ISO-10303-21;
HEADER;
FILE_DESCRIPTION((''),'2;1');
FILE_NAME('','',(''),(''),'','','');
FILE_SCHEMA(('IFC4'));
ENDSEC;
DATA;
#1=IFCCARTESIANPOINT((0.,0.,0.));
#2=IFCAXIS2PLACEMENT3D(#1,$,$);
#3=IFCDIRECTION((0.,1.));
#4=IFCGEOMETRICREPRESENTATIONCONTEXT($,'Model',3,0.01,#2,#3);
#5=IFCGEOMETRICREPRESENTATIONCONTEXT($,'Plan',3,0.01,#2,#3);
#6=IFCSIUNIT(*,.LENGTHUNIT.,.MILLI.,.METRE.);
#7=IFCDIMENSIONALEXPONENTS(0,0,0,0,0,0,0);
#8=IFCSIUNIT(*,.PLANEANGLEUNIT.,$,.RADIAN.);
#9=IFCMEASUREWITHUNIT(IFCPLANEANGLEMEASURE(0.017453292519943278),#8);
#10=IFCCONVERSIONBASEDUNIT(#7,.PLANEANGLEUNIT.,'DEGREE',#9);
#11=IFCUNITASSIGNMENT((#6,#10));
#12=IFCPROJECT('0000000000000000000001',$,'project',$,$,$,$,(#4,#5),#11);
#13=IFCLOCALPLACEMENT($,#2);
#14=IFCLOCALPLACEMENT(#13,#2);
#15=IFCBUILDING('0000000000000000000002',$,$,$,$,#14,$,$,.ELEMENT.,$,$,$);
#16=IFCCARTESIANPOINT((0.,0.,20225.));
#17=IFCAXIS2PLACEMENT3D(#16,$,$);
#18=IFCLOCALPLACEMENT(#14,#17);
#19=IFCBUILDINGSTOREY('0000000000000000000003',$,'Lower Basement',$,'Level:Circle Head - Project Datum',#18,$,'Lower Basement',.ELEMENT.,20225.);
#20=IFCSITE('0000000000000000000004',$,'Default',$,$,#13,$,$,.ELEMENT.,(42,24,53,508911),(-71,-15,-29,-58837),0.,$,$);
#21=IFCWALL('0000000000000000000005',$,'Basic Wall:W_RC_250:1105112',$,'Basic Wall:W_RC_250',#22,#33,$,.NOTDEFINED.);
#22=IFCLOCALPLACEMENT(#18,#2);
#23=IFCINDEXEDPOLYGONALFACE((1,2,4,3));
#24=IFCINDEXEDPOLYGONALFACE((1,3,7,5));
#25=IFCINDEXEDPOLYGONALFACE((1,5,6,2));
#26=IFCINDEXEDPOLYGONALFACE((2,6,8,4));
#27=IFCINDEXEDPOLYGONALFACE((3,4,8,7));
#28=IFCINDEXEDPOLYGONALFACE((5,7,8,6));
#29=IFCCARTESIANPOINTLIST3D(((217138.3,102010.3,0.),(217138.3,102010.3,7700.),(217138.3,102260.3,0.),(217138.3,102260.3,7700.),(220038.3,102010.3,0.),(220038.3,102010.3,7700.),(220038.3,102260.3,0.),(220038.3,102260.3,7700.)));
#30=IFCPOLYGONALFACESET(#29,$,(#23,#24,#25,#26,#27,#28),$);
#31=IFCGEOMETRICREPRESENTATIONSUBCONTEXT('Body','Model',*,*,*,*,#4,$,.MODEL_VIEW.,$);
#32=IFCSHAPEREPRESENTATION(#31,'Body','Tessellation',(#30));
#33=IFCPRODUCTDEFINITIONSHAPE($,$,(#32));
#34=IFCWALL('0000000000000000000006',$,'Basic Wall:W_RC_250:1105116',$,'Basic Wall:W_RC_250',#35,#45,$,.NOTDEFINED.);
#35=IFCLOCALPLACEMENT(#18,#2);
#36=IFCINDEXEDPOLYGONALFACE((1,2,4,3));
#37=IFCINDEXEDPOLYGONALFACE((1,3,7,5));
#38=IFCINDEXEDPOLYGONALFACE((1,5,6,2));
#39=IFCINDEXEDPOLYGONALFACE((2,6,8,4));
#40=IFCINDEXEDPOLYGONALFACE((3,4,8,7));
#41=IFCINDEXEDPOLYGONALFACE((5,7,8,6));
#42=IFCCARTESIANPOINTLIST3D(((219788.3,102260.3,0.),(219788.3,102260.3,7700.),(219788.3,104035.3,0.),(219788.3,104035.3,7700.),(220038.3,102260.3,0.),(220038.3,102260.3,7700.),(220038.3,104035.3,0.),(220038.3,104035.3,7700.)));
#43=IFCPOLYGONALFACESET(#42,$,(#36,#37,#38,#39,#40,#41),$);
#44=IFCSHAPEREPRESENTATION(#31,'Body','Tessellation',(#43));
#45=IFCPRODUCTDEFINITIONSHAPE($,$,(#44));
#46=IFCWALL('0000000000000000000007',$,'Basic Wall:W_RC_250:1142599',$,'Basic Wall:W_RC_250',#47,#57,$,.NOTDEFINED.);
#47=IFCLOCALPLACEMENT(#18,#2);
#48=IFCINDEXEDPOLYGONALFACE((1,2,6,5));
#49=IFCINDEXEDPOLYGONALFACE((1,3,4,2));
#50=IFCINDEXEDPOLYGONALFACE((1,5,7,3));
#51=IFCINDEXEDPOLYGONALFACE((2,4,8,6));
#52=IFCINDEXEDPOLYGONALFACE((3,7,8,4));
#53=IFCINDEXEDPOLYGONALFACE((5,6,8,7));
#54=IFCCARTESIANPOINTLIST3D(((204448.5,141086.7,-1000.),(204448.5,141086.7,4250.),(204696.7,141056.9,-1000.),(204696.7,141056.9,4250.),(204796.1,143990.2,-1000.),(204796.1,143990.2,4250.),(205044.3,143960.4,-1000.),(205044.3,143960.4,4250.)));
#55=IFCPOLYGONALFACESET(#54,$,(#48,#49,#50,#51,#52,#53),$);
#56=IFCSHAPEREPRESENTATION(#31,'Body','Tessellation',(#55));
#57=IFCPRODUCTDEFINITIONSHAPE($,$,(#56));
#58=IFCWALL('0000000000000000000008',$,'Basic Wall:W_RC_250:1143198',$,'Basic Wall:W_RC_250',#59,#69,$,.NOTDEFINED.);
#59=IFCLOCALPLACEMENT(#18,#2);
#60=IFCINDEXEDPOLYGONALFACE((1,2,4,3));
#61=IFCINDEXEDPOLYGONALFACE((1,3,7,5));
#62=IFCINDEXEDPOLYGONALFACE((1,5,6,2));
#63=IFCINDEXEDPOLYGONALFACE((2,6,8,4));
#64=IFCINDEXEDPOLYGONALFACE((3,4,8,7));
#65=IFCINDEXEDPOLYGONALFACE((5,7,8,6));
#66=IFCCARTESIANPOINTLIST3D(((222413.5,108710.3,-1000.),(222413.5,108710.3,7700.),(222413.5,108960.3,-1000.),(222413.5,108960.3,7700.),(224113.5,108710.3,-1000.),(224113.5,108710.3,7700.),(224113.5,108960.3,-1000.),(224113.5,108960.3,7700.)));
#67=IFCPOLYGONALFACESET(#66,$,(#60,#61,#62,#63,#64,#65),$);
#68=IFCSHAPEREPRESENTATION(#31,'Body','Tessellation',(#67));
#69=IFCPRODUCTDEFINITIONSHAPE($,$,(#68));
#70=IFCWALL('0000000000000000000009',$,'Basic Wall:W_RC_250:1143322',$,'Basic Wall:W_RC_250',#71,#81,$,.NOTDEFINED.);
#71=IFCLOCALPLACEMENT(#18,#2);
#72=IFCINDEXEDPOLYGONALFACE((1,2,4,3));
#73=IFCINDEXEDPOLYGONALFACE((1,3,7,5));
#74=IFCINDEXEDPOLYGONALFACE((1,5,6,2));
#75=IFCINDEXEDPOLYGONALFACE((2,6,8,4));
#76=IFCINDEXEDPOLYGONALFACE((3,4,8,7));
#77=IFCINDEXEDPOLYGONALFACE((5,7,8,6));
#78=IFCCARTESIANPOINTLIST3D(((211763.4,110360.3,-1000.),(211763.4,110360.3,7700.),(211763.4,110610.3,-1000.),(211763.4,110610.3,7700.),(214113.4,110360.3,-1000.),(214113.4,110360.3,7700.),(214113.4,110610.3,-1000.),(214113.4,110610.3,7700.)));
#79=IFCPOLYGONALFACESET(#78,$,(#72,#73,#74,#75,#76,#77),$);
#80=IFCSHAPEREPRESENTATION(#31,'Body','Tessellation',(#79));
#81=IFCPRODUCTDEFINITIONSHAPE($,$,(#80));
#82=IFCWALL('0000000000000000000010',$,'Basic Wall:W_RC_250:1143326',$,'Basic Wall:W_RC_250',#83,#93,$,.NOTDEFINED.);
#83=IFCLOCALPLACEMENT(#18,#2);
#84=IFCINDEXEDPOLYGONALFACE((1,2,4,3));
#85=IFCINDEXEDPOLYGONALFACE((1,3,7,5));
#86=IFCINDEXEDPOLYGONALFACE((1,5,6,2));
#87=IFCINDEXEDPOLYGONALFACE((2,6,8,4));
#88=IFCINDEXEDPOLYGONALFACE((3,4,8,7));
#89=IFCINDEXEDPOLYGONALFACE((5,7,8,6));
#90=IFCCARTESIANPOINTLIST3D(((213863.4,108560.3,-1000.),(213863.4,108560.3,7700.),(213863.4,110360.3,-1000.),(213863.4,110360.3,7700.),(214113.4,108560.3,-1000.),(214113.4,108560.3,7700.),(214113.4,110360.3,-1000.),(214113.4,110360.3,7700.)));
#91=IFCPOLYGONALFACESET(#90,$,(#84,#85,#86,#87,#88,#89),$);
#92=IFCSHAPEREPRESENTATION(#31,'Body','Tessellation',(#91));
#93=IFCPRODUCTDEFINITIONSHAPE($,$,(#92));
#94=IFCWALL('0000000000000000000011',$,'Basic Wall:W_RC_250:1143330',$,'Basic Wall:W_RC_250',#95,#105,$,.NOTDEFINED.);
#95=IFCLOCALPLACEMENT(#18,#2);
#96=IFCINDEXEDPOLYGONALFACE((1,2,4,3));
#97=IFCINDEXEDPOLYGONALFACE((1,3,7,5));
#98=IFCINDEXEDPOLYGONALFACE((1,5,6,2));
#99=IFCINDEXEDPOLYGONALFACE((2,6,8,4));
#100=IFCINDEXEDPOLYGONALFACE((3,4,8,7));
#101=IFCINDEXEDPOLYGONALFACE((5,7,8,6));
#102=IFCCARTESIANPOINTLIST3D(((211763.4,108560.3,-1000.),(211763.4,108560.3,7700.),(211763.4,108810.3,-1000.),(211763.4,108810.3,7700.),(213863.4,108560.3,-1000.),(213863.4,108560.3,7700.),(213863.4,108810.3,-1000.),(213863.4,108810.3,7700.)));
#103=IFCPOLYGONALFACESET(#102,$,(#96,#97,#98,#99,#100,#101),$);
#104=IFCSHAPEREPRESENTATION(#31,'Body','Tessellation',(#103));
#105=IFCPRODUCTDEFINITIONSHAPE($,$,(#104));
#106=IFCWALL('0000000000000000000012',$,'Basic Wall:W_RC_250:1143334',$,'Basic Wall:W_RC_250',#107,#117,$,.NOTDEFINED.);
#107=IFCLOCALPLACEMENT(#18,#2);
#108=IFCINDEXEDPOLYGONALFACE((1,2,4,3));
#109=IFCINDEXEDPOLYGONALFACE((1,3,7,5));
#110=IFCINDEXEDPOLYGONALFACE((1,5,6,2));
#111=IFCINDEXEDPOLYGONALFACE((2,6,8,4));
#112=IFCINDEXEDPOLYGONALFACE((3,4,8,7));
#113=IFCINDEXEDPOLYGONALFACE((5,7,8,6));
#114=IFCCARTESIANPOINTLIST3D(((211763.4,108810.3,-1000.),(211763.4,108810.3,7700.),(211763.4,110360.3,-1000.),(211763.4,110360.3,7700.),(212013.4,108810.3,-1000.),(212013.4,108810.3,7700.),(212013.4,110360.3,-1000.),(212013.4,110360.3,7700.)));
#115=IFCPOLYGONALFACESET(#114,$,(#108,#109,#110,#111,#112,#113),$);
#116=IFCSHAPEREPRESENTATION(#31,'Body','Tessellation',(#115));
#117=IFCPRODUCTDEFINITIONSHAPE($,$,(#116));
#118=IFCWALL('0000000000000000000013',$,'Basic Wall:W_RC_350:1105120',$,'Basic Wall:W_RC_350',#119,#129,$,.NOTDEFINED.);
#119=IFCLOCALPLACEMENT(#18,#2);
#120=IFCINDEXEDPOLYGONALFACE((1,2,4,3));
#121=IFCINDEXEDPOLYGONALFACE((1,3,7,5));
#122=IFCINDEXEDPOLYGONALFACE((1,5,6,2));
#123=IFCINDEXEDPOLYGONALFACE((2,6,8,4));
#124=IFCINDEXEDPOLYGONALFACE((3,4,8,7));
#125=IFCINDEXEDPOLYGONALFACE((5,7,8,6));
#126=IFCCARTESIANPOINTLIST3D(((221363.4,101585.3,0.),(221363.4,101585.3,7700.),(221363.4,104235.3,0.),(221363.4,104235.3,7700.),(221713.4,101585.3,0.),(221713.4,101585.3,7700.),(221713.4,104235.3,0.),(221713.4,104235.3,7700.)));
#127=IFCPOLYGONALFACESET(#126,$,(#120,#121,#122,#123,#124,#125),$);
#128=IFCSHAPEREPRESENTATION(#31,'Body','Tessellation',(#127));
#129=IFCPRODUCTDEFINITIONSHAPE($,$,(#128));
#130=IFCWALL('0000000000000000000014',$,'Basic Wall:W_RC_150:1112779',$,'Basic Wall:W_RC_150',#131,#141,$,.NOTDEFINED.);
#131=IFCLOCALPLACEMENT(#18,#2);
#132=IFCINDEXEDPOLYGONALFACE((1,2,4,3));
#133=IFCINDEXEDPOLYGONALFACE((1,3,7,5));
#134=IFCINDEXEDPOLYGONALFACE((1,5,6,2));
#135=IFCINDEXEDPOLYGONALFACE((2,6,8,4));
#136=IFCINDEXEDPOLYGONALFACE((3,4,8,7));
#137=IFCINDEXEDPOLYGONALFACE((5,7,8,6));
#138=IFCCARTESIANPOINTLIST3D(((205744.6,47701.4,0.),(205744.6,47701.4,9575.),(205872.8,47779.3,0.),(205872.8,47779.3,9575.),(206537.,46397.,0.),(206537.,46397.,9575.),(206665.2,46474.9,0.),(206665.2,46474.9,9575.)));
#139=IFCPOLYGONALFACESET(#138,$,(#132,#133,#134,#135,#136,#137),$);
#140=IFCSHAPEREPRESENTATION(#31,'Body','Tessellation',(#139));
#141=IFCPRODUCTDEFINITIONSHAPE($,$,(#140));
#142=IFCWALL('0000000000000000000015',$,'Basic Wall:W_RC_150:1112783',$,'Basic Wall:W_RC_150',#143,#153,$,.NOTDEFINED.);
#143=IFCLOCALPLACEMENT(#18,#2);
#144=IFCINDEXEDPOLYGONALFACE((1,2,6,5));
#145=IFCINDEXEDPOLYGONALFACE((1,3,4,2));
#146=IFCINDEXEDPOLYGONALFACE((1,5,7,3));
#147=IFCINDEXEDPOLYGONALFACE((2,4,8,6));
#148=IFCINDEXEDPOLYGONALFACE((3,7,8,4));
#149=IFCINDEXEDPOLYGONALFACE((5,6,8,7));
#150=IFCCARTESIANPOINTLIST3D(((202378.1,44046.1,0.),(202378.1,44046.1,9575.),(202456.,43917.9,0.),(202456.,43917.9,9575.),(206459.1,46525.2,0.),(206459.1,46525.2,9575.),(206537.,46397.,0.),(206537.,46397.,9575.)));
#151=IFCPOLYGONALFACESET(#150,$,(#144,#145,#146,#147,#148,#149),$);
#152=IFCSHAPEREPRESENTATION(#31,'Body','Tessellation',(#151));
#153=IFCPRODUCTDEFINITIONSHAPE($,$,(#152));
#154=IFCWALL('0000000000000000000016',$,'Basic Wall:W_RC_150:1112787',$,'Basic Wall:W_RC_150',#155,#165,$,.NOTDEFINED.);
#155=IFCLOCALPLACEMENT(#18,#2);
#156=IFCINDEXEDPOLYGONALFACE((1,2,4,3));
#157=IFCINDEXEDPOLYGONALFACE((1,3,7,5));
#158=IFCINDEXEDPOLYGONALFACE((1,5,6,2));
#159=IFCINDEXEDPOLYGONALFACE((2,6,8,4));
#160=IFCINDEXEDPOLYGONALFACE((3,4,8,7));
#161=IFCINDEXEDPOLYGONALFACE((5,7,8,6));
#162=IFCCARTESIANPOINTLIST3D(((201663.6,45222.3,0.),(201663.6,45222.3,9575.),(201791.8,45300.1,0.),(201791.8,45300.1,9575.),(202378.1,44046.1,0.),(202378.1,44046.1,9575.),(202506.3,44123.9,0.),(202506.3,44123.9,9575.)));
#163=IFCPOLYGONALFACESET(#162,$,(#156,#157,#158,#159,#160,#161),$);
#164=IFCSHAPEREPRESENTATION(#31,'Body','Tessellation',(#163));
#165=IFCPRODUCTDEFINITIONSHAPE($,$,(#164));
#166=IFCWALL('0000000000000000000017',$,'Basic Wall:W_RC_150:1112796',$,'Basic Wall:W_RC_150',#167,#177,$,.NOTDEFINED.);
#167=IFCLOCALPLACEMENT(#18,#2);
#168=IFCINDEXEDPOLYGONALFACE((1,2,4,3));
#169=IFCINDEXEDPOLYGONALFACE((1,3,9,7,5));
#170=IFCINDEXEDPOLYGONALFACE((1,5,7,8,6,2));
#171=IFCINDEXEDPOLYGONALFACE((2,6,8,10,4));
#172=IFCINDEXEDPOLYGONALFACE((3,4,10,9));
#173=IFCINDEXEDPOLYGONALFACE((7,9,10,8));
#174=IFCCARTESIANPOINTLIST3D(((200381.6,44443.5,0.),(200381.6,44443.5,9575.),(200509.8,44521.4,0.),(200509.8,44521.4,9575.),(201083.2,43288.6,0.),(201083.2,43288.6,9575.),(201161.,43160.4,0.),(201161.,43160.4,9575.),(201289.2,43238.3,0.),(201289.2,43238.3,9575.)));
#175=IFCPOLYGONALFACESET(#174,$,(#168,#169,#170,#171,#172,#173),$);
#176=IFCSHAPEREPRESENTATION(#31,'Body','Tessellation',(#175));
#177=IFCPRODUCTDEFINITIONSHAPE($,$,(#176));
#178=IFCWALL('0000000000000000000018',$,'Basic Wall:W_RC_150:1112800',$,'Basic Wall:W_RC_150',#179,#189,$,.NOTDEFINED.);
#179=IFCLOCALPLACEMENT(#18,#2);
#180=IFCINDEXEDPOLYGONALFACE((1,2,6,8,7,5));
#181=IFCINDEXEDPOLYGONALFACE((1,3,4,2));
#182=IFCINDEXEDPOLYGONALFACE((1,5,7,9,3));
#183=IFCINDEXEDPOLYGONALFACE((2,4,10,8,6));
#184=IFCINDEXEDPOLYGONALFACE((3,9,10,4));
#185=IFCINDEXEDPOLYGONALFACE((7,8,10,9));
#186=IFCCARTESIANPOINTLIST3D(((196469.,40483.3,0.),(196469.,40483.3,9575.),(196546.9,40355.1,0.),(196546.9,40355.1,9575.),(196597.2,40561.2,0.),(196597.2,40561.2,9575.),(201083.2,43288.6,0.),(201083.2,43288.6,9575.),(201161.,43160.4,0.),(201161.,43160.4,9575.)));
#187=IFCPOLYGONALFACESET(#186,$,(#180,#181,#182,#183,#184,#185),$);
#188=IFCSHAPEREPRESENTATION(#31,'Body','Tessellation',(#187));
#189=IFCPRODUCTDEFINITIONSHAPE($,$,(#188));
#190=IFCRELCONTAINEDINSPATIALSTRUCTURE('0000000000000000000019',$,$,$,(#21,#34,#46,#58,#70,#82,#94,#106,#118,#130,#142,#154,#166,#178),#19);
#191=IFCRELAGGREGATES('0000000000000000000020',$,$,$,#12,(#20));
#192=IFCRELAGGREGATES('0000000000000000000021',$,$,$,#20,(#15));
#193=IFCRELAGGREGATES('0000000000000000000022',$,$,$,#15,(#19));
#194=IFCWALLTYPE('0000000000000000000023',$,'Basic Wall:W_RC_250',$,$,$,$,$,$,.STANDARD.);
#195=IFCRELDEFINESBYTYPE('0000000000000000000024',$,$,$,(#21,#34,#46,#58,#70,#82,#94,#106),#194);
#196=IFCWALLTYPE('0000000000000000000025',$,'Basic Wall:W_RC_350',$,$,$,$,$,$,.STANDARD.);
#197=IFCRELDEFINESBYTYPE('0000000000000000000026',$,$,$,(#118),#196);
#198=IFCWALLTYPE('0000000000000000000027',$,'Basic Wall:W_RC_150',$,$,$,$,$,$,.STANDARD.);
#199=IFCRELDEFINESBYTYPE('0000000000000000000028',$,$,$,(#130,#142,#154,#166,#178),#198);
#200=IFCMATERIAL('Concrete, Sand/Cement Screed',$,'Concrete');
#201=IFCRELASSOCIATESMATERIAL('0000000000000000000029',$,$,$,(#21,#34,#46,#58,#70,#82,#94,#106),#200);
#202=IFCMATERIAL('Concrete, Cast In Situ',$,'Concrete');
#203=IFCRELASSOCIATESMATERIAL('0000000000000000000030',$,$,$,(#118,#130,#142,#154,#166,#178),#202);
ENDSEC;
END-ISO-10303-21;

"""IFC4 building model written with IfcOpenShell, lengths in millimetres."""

from ifc_helpers import new_model, entity, si_unit, converted_unit, direction, frame, origin, place, context, subcontext, project, spatial, indexed_curve, outline, extrude, material, type_object, element, save


model = new_model("IFC4")

# Units and contexts
model_context = context("Model", 3, precision=0.01, world=origin(), true_north=direction((0.0, 1.0)))
plan_context = context("Plan", 3, precision=0.01, world=origin(), true_north=direction((0.0, 1.0)))
body_context = subcontext(model_context, "Body", "Model", "MODEL_VIEW")
ifc_project = project(units=[si_unit("LENGTHUNIT", "METRE", prefix="MILLI"), converted_unit("PLANEANGLEUNIT", "DEGREE", entity("IfcPlaneAngleMeasure", 0.017453292519943278), si_unit("PLANEANGLEUNIT", "RADIAN"), dimensions=[0, 0, 0, 0, 0, 0, 0])], contexts=[model_context, plan_context])

# Site, building, storey
site_placement = place(None, origin())
site = spatial("IfcSite", under=ifc_project, at=site_placement, Name="Default", CompositionType="ELEMENT", RefLatitude=(42, 24, 53, 508911), RefLongitude=(-71, -15, -29, -58837), RefElevation=0.0)
building_placement = place(site_placement, origin())
building = spatial("IfcBuilding", under=site, at=building_placement, CompositionType="ELEMENT")
storey_placement = place(building_placement, frame((0.0, 0.0, 20225.0)))
storey = spatial("IfcBuildingStorey", under=building, at=storey_placement, Name="Lower Basement", ObjectType="Level:Circle Head - Project Datum", LongName="Lower Basement", CompositionType="ELEMENT", Elevation=20225.0)

# Walls
ifc_material_1 = material(Name="Concrete, Cast In Situ", Category="Concrete")
ifc_material_2 = material(Name="Concrete, Sand/Cement Screed", Category="Concrete")
wall_type_1 = type_object("IfcWallType", Name="Basic Wall:W_RC_250", PredefinedType="STANDARD")
wall_1_placement = place(storey_placement, frame((220038.3, 102135.3, 0.0), z_axis=(0.0, 0.0, 1.0), x_axis=(-1.0, 0.0, 0.0)))
element("IfcWall", 1, at=wall_1_placement, inside=storey, type_object=wall_type_1, material=ifc_material_2, Name="Basic Wall:W_RC_250:1105112", ObjectType="Basic Wall:W_RC_250", PredefinedType="NOTDEFINED", context=body_context, shape_type="SweptSolid", body=[
    extrude(outline(indexed_curve([(2900.0, 125.0), (0.0, 125.0), (0.0, -125.0), (2900.0, -125.0), (2900.0, 125.0)], self_intersect=False)), origin(), (0.0, 0.0, 1.0), 7700.0),
])
wall_2_placement = place(storey_placement, frame((219913.3, 104035.3, 0.0), z_axis=(0.0, 0.0, 1.0), x_axis=(0.0, -1.0, 0.0)))
element("IfcWall", 2, at=wall_2_placement, inside=storey, type_object=wall_type_1, material=ifc_material_2, Name="Basic Wall:W_RC_250:1105116", ObjectType="Basic Wall:W_RC_250", PredefinedType="NOTDEFINED", context=body_context, shape_type="SweptSolid", body=[
    extrude(outline(indexed_curve([(1775.0, 125.0), (0.0, 125.0), (0.0, -125.0), (1775.0, -125.0), (1775.0, 125.0)], self_intersect=False)), origin(), (0.0, 0.0, 1.0), 7700.0),
])
wall_3_placement = place(storey_placement, frame((204572.6, 141071.8, -1000.0), z_axis=(0.0, 0.0, 1.0), x_axis=(0.118881, 0.992909, 0.0)))
element("IfcWall", 3, at=wall_3_placement, inside=storey, type_object=wall_type_1, material=ifc_material_2, Name="Basic Wall:W_RC_250:1142599", ObjectType="Basic Wall:W_RC_250", PredefinedType="NOTDEFINED", context=body_context, shape_type="SweptSolid", body=[
    extrude(outline(indexed_curve([(2924.2, 125.0), (0.0, 125.0), (0.0, -125.0), (2924.2, -125.0), (2924.2, 125.0)], self_intersect=False)), origin(), (0.0, 0.0, 1.0), 5250.0),
])
wall_4_placement = place(storey_placement, frame((222413.5, 108835.3, -1000.0)))
element("IfcWall", 4, at=wall_4_placement, inside=storey, type_object=wall_type_1, material=ifc_material_2, Name="Basic Wall:W_RC_250:1143198", ObjectType="Basic Wall:W_RC_250", PredefinedType="NOTDEFINED", context=body_context, shape_type="SweptSolid", body=[
    extrude(outline(indexed_curve([(1700.0, 125.0), (0.0, 125.0), (0.0, -125.0), (1700.0, -125.0), (1700.0, 125.0)], self_intersect=False)), origin(), (0.0, 0.0, 1.0), 8700.0),
])
wall_5_placement = place(storey_placement, frame((211763.4, 110485.3, -1000.0)))
element("IfcWall", 5, at=wall_5_placement, inside=storey, type_object=wall_type_1, material=ifc_material_2, Name="Basic Wall:W_RC_250:1143322", ObjectType="Basic Wall:W_RC_250", PredefinedType="NOTDEFINED", context=body_context, shape_type="SweptSolid", body=[
    extrude(outline(indexed_curve([(2350.0, 125.0), (0.0, 125.0), (0.0, -125.0), (2350.0, -125.0), (2350.0, 125.0)], self_intersect=False)), origin(), (0.0, 0.0, 1.0), 8700.0),
])
wall_6_placement = place(storey_placement, frame((213988.4, 110360.3, -1000.0), z_axis=(0.0, 0.0, 1.0), x_axis=(0.0, -1.0, 0.0)))
element("IfcWall", 6, at=wall_6_placement, inside=storey, type_object=wall_type_1, material=ifc_material_2, Name="Basic Wall:W_RC_250:1143326", ObjectType="Basic Wall:W_RC_250", PredefinedType="NOTDEFINED", context=body_context, shape_type="SweptSolid", body=[
    extrude(outline(indexed_curve([(1800.0, 125.0), (0.0, 125.0), (0.0, -125.0), (1800.0, -125.0), (1800.0, 125.0)], self_intersect=False)), origin(), (0.0, 0.0, 1.0), 8700.0),
])
wall_7_placement = place(storey_placement, frame((213863.4, 108685.3, -1000.0), z_axis=(0.0, 0.0, 1.0), x_axis=(-1.0, 0.0, 0.0)))
element("IfcWall", 7, at=wall_7_placement, inside=storey, type_object=wall_type_1, material=ifc_material_2, Name="Basic Wall:W_RC_250:1143330", ObjectType="Basic Wall:W_RC_250", PredefinedType="NOTDEFINED", context=body_context, shape_type="SweptSolid", body=[
    extrude(outline(indexed_curve([(2100.0, 125.0), (0.0, 125.0), (0.0, -125.0), (2100.0, -125.0), (2100.0, 125.0)], self_intersect=False)), origin(), (0.0, 0.0, 1.0), 8700.0),
])
wall_8_placement = place(storey_placement, frame((211888.4, 108810.3, -1000.0), z_axis=(0.0, 0.0, 1.0), x_axis=(0.0, 1.0, 0.0)))
element("IfcWall", 8, at=wall_8_placement, inside=storey, type_object=wall_type_1, material=ifc_material_2, Name="Basic Wall:W_RC_250:1143334", ObjectType="Basic Wall:W_RC_250", PredefinedType="NOTDEFINED", context=body_context, shape_type="SweptSolid", body=[
    extrude(outline(indexed_curve([(1550.0, 125.0), (0.0, 125.0), (0.0, -125.0), (1550.0, -125.0), (1550.0, 125.0)], self_intersect=False)), origin(), (0.0, 0.0, 1.0), 8700.0),
])
wall_type_2 = type_object("IfcWallType", Name="Basic Wall:W_RC_350", PredefinedType="STANDARD")
wall_9_placement = place(storey_placement, frame((221538.4, 101585.3, 0.0), z_axis=(0.0, 0.0, 1.0), x_axis=(0.0, 1.0, 0.0)))
element("IfcWall", 9, at=wall_9_placement, inside=storey, type_object=wall_type_2, material=ifc_material_1, Name="Basic Wall:W_RC_350:1105120", ObjectType="Basic Wall:W_RC_350", PredefinedType="NOTDEFINED", context=body_context, shape_type="SweptSolid", body=[
    extrude(outline(indexed_curve([(2650.0, 175.0), (0.0, 175.0), (0.0, -175.0), (2650.0, -175.0), (2650.0, 175.0)], self_intersect=False)), origin(), (0.0, 0.0, 1.0), 7700.0),
])
wall_type_3 = type_object("IfcWallType", Name="Basic Wall:W_RC_150", PredefinedType="STANDARD")
wall_10_placement = place(storey_placement, frame((205808.7, 47740.3, 0.0), z_axis=(0.0, 0.0, 1.0), x_axis=(0.519187, -0.854661, 0.0)))
element("IfcWall", 10, at=wall_10_placement, inside=storey, type_object=wall_type_3, material=ifc_material_1, Name="Basic Wall:W_RC_150:1112779", ObjectType="Basic Wall:W_RC_150", PredefinedType="NOTDEFINED", context=body_context, shape_type="SweptSolid", body=[
    extrude(outline(indexed_curve([(1526.2, 75.0), (0.0, 75.0), (0.0, -75.0), (1526.2, -75.0), (1526.2, 75.0)], self_intersect=False)), origin(), (0.0, 0.0, 1.0), 9575.0),
])
wall_11_placement = place(storey_placement, frame((206498.0, 46461.1, 0.0), z_axis=(0.0, 0.0, 1.0), x_axis=(-0.854661, -0.519187, 0.0)))
element("IfcWall", 11, at=wall_11_placement, inside=storey, type_object=wall_type_3, material=ifc_material_1, Name="Basic Wall:W_RC_150:1112783", ObjectType="Basic Wall:W_RC_150", PredefinedType="NOTDEFINED", context=body_context, shape_type="SweptSolid", body=[
    extrude(outline(indexed_curve([(4775.0, 75.0), (0.0, 75.0), (0.0, -75.0), (4775.0, -75.0), (4775.0, 75.0)], self_intersect=False)), origin(), (0.0, 0.0, 1.0), 9575.0),
])
wall_12_placement = place(storey_placement, frame((202442.2, 44085.0, 0.0), z_axis=(0.0, 0.0, 1.0), x_axis=(-0.519187, 0.854661, 0.0)))
element("IfcWall", 12, at=wall_12_placement, inside=storey, type_object=wall_type_3, material=ifc_material_1, Name="Basic Wall:W_RC_150:1112787", ObjectType="Basic Wall:W_RC_150", PredefinedType="NOTDEFINED", context=body_context, shape_type="SweptSolid", body=[
    extrude(outline(indexed_curve([(1376.2, 75.0), (0.0, 75.0), (0.0, -75.0), (1376.2, -75.0), (1376.2, 75.0)], self_intersect=False)), origin(), (0.0, 0.0, 1.0), 9575.0),
])
wall_13_placement = place(storey_placement, frame((200445.7, 44482.4, 0.0), z_axis=(0.0, 0.0, 1.0), x_axis=(0.519194, -0.854656, 0.0)))
element("IfcWall", 13, at=wall_13_placement, inside=storey, type_object=wall_type_3, material=ifc_material_1, Name="Basic Wall:W_RC_150:1112796", ObjectType="Basic Wall:W_RC_150", PredefinedType="NOTDEFINED", context=body_context, shape_type="SweptSolid", body=[
    extrude(outline(indexed_curve([(1501.3, -75.0), (1501.2, 75.0), (0.0, 75.0), (0.0, -75.0), (1351.3, -75.0), (1501.3, -75.0)], self_intersect=False)), origin(), (0.0, 0.0, 1.0), 9575.0),
])
wall_14_placement = place(storey_placement, frame((201122.1, 43224.5, 0.0), z_axis=(0.0, 0.0, 1.0), x_axis=(-0.854469, -0.519502, 0.0)))
element("IfcWall", 14, at=wall_14_placement, inside=storey, type_object=wall_type_3, material=ifc_material_1, Name="Basic Wall:W_RC_150:1112800", ObjectType="Basic Wall:W_RC_150", PredefinedType="NOTDEFINED", context=body_context, shape_type="SweptSolid", body=[
    extrude(outline(indexed_curve([(5400.0, -75.0), (5400.1, 75.0), (0.1, 75.0), (0.0, -75.0), (5250.0, -75.0), (5400.0, -75.0)], self_intersect=False)), origin(), (0.0, 0.0, 1.0), 9575.0),
])

save(model, "model.ifc")
